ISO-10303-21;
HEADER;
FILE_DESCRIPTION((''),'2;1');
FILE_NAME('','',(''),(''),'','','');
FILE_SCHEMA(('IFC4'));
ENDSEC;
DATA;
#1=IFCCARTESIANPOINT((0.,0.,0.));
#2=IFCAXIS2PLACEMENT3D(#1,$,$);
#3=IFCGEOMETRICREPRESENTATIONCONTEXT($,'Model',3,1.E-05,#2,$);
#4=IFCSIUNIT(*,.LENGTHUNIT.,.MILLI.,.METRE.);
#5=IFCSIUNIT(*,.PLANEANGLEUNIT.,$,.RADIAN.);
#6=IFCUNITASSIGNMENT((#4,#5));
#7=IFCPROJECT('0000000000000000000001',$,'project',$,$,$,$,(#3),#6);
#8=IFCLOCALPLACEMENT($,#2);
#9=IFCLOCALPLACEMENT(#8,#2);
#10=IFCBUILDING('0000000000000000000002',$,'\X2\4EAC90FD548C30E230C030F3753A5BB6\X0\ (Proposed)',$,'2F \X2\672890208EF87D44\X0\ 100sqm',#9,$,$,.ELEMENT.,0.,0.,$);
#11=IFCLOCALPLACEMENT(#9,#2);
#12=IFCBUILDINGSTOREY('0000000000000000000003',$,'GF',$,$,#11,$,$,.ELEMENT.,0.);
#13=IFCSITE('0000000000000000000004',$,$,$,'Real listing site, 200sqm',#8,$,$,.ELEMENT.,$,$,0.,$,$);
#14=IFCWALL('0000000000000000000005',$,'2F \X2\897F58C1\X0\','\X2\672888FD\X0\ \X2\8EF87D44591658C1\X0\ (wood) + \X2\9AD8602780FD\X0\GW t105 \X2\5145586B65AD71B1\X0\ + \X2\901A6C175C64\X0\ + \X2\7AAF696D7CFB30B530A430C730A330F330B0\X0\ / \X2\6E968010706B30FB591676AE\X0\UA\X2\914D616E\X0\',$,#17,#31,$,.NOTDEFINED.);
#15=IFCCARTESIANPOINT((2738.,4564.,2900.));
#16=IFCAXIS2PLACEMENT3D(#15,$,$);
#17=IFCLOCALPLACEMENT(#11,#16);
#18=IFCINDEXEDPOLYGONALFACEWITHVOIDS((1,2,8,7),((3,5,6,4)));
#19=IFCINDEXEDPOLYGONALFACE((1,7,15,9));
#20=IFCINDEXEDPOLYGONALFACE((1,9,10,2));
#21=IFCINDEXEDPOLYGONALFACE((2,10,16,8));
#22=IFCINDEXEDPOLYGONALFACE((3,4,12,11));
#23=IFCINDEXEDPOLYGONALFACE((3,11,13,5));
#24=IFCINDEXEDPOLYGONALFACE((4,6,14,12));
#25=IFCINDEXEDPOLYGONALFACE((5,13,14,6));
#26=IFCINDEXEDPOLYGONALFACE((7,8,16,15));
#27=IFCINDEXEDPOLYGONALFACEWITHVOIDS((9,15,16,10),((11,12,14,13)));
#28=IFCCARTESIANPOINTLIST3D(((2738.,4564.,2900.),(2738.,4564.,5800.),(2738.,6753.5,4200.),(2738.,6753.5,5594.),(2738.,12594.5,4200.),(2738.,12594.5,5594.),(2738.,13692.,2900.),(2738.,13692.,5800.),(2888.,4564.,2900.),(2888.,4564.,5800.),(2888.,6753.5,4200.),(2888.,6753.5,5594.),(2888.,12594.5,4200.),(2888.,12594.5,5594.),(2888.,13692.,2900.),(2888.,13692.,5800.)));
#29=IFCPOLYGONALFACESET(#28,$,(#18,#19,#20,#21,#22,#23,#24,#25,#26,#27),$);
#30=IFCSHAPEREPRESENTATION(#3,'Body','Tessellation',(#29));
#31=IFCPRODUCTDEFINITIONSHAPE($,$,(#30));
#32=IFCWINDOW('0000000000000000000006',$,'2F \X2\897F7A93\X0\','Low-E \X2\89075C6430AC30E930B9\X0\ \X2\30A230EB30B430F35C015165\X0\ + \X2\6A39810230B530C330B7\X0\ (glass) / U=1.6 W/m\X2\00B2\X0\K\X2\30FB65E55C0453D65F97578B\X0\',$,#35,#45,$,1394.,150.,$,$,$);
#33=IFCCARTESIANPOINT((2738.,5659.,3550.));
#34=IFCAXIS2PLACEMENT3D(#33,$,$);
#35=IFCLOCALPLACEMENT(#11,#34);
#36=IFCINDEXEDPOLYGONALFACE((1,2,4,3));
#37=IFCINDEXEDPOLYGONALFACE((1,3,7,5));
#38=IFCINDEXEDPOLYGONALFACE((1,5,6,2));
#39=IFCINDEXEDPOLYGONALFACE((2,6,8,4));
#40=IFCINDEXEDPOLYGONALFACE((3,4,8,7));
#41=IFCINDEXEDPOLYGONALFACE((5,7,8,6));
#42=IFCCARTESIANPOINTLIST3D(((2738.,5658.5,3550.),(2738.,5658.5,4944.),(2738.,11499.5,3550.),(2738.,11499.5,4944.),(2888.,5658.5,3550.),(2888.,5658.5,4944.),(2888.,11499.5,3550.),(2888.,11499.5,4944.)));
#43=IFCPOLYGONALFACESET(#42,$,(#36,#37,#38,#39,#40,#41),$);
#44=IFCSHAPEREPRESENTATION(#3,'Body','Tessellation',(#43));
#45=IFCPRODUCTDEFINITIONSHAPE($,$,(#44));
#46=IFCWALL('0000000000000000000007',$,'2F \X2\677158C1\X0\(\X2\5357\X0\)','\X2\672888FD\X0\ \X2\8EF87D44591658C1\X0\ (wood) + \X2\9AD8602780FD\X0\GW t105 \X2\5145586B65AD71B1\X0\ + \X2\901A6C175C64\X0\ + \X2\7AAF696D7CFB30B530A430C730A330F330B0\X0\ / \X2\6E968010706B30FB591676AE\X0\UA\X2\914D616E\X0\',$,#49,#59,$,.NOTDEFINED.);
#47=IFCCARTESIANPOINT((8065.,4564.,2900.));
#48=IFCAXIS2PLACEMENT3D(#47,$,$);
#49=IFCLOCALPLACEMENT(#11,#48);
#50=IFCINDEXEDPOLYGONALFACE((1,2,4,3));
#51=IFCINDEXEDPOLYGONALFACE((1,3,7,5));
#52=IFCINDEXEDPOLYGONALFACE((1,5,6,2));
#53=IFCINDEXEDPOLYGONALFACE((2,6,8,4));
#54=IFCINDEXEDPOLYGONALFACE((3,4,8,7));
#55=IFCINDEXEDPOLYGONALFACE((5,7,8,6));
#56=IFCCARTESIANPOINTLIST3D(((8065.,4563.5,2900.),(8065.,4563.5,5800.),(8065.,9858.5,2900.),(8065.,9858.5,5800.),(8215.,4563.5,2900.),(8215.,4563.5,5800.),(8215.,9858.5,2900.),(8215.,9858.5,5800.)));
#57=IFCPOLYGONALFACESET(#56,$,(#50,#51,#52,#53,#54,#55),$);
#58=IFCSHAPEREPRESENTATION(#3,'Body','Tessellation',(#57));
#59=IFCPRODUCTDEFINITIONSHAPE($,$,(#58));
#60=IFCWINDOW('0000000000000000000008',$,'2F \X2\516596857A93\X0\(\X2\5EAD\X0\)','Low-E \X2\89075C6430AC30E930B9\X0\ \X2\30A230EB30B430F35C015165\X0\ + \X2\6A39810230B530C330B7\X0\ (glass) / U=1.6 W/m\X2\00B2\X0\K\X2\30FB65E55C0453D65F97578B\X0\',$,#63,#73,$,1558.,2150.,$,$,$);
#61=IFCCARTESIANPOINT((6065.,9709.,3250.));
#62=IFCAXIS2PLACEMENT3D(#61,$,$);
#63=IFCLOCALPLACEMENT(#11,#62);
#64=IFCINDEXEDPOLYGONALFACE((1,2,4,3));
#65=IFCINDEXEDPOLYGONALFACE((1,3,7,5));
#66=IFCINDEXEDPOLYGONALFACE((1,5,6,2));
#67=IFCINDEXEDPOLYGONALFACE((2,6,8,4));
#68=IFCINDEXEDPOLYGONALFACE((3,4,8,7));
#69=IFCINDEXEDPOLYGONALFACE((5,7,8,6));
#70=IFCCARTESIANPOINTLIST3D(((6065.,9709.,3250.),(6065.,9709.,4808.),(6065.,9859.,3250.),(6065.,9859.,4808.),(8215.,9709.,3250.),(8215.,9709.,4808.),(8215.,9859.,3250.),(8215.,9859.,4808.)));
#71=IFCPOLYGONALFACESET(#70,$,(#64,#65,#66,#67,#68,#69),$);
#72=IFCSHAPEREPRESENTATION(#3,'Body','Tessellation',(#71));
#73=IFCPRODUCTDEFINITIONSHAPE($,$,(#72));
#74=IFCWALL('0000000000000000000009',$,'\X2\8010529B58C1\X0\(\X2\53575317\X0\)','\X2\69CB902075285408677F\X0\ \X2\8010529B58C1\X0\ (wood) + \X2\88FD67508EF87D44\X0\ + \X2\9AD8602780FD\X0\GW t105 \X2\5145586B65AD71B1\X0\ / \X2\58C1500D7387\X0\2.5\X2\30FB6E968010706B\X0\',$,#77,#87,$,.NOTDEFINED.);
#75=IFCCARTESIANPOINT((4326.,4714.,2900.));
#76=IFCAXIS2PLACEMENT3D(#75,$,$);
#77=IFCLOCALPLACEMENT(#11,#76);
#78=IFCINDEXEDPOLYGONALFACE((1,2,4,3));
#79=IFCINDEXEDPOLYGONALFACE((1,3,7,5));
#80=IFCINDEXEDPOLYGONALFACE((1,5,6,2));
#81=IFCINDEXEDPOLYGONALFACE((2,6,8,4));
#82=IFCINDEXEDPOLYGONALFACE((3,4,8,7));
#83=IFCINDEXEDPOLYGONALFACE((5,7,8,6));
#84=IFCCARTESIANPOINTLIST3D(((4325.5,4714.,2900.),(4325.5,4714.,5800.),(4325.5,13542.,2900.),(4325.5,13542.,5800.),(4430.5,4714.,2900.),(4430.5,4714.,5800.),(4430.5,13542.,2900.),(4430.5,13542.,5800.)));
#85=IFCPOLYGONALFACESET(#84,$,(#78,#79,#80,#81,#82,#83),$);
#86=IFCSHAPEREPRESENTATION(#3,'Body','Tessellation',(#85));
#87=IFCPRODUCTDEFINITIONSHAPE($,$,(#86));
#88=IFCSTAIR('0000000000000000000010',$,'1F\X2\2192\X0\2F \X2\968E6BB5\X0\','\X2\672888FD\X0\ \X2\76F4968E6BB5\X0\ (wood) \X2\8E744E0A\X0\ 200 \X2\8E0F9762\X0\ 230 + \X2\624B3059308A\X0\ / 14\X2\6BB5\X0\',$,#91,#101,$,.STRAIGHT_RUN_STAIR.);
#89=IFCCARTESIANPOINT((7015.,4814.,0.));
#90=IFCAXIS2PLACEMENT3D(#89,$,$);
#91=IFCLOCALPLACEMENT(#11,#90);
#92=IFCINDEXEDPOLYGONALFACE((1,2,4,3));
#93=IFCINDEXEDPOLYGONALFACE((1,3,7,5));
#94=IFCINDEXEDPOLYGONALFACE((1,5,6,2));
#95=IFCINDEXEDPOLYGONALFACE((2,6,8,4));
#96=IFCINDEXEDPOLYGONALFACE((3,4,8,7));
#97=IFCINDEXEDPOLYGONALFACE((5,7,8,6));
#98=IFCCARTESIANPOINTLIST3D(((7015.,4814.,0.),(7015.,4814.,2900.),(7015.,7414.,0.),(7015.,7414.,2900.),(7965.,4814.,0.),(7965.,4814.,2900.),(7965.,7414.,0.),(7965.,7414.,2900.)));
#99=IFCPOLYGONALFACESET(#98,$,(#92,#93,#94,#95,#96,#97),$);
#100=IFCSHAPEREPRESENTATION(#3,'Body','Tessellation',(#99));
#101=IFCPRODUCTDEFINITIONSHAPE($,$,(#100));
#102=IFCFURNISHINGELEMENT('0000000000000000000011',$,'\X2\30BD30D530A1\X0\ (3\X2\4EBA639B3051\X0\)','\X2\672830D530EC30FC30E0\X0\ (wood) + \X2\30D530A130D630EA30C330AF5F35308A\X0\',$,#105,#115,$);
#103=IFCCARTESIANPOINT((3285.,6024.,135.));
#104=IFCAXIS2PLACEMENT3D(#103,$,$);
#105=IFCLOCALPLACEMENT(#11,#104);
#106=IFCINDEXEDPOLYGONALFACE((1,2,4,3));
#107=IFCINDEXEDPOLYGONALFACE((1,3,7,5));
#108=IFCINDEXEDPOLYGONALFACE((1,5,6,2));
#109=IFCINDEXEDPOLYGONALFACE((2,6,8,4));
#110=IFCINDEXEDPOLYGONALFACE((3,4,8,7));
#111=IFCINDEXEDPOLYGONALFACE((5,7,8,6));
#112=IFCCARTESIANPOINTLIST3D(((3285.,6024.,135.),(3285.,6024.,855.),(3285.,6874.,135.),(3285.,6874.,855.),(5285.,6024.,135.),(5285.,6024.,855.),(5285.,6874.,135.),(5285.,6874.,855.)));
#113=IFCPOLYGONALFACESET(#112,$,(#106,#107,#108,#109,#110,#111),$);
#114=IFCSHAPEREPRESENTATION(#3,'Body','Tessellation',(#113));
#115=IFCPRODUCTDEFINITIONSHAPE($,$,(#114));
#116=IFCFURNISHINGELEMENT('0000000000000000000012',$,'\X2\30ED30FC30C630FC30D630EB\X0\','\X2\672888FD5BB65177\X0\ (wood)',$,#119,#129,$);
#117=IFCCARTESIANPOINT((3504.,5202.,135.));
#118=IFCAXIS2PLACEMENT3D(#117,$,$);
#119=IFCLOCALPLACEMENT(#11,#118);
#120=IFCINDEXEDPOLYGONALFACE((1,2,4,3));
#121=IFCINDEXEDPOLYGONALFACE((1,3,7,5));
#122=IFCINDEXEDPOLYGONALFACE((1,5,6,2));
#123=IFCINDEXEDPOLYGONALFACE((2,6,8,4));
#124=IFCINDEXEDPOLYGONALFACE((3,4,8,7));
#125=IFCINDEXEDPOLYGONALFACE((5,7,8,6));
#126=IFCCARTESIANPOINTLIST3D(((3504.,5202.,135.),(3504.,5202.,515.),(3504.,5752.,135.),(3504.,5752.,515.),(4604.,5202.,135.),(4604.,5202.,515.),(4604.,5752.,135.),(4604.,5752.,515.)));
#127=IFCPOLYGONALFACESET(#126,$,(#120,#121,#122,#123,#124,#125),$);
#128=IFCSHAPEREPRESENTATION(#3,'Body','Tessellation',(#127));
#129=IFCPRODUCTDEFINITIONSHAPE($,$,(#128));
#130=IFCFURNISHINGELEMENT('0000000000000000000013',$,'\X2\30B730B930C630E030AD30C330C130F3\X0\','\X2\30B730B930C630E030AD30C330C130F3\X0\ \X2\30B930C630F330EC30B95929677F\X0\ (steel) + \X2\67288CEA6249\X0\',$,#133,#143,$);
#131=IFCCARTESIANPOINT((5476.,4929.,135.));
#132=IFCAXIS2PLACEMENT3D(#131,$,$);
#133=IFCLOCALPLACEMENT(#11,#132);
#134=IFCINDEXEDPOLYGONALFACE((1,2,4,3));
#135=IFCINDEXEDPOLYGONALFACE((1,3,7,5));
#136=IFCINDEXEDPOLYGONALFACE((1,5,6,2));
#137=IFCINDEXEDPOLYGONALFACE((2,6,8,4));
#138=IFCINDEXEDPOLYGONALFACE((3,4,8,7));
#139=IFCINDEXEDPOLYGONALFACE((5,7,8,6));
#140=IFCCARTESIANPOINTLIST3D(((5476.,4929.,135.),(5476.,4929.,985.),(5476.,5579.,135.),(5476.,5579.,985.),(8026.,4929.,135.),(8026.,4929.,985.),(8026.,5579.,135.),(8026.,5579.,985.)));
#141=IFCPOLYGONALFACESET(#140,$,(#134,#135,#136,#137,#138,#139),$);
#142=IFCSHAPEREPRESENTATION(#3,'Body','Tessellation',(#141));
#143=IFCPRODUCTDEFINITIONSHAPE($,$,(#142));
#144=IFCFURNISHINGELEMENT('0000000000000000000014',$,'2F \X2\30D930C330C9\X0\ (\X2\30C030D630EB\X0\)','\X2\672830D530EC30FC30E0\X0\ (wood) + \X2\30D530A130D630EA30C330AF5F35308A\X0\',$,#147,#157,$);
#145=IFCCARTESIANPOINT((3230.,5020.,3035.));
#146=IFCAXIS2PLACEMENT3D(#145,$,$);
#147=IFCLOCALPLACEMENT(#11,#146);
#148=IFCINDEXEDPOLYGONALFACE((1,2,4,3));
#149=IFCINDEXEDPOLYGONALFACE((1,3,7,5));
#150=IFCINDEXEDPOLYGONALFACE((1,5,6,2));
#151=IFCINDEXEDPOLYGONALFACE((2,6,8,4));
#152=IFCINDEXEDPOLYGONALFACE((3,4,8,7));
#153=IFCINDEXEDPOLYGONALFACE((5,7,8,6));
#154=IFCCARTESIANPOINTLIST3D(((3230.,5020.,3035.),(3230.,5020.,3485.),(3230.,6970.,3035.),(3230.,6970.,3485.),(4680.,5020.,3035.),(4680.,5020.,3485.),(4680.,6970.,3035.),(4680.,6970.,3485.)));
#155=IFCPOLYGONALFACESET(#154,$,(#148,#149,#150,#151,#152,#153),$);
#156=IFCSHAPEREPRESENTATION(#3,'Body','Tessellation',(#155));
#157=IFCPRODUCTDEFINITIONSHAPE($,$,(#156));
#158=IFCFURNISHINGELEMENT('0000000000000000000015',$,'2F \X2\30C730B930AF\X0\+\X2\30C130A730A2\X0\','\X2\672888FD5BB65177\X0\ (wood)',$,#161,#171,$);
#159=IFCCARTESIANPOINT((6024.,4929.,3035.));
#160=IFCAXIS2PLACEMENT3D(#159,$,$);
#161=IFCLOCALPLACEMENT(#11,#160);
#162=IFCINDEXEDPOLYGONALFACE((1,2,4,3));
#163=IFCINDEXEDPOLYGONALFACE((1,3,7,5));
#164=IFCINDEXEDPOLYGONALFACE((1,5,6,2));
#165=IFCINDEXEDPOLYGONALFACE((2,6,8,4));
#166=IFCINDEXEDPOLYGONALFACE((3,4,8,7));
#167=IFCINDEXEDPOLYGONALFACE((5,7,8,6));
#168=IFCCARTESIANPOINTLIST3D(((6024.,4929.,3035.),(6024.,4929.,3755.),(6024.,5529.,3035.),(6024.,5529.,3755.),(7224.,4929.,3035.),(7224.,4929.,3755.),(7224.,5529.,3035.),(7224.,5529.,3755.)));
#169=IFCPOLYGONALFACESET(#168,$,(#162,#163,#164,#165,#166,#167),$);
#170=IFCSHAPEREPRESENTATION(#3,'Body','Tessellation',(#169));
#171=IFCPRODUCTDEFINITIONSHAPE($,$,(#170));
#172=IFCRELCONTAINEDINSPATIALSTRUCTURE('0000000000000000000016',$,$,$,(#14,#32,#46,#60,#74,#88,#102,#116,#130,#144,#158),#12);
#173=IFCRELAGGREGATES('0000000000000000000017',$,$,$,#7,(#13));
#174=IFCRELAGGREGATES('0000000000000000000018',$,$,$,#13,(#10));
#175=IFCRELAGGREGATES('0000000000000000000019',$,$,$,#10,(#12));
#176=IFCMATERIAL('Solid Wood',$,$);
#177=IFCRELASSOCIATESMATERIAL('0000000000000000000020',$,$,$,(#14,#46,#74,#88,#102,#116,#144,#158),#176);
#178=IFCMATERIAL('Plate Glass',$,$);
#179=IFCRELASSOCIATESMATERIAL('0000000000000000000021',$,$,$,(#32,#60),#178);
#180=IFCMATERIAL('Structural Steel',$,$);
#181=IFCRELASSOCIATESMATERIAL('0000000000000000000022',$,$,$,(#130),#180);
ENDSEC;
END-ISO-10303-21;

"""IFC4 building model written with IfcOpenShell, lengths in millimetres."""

from ifc_helpers import new_model, si_unit, frame, frame_2d, origin, place, context, project, spatial, rectangle, extrude, material, element, fill, save


model = new_model("IFC4")

# Units and contexts
model_context = context("Model", 3, precision=1e-05, world=origin())
ifc_project = project(units=[si_unit("LENGTHUNIT", "METRE", prefix="MILLI"), si_unit("PLANEANGLEUNIT", "RADIAN")], contexts=[model_context])

# Site, building, storey
site_placement = place(None, origin())
site = spatial("IfcSite", under=ifc_project, at=site_placement, ObjectType="Real listing site, 200sqm", CompositionType="ELEMENT", RefElevation=0.0)
building_placement = place(site_placement, origin())
building = spatial("IfcBuilding", under=site, at=building_placement, Name="京都和モダン町家 (Proposed)", ObjectType="2F 木造軸組 100sqm", CompositionType="ELEMENT", ElevationOfRefHeight=0.0, ElevationOfTerrain=0.0)
storey_placement = place(building_placement, origin())
storey = spatial("IfcBuildingStorey", under=building, at=storey_placement, Name="GF", CompositionType="ELEMENT", Elevation=0.0)

# Shared definitions
ifc_material_1 = material(Name="Solid Wood")

# Shared definitions
ifc_material_2 = material(Name="Plate Glass")

# Walls, openings, windows
wall_1_placement = place(storey_placement, frame((2738.0, 4564.0, 2900.0)))
wall_1 = element("IfcWall", 1, at=wall_1_placement, inside=storey, material=ifc_material_1, Name="2F 西壁", Description="木製 軸組外壁 (wood) + 高性能GW t105 充填断熱 + 通気層 + 窯業系サイディング / 準耐火・外皮UA配慮", PredefinedType="NOTDEFINED", context=model_context, shape_type="SweptSolid", body=[
    extrude(rectangle(XDim=150.0, YDim=9128.0, at=frame_2d((75.0, 4564.0))), frame((2738.0, 4564.0, 2900.0)), (0.0, 0.0, 1.0), 2900.0),
])
opening_1_placement = place(storey_placement, frame((2738.0, 5659.0, 3550.0)))
opening_1 = element("IfcOpeningElement", 2, at=opening_1_placement, cuts=wall_1, PredefinedType="NOTDEFINED", context=model_context, shape_type="SweptSolid", body=[
    extrude(rectangle(XDim=150.0, YDim=5841.0, at=frame_2d((75.0, 2920.0))), frame((2738.0, 5659.0, 3550.0)), (0.0, 0.0, 1.0), 1394.0),
])
window_1_placement = place(storey_placement, frame((2738.0, 5659.0, 3550.0)))
window_1 = element("IfcWindow", 3, at=window_1_placement, inside=storey, material=ifc_material_2, Name="2F 西窓", Description="Low-E 複層ガラス アルゴン封入 + 樹脂サッシ (glass) / U=1.6 W/m²K・日射取得型", OverallHeight=1394.0, OverallWidth=150.0, context=model_context, shape_type="SweptSolid", body=[
    extrude(rectangle(XDim=150.0, YDim=5841.0, at=frame_2d((75.0, 2920.0))), frame((2738.0, 5659.0, 3550.0)), (0.0, 0.0, 1.0), 1394.0),
])
fill(opening_1, window_1)
wall_2_placement = place(storey_placement, frame((8065.0, 4564.0, 2900.0)))
wall_2 = element("IfcWall", 4, at=wall_2_placement, inside=storey, material=ifc_material_1, Name="2F 東壁(南)", Description="木製 軸組外壁 (wood) + 高性能GW t105 充填断熱 + 通気層 + 窯業系サイディング / 準耐火・外皮UA配慮", PredefinedType="NOTDEFINED", context=model_context, shape_type="SweptSolid", body=[
    extrude(rectangle(XDim=150.0, YDim=5295.0, at=frame_2d((75.0, 2647.0))), frame((8065.0, 4564.0, 2900.0)), (0.0, 0.0, 1.0), 2900.0),
])
opening_2_placement = place(storey_placement, frame((6065.0, 9709.0, 3250.0)))
opening_2 = element("IfcOpeningElement", 5, at=opening_2_placement, cuts=wall_2, PredefinedType="NOTDEFINED", context=model_context, shape_type="SweptSolid", body=[
    extrude(rectangle(XDim=2150.0, YDim=150.0, at=frame_2d((1075.0, 75.0))), frame((6065.0, 9709.0, 3250.0)), (0.0, 0.0, 1.0), 1558.0),
])
window_2_placement = place(storey_placement, frame((6065.0, 9709.0, 3250.0)))
window_2 = element("IfcWindow", 6, at=window_2_placement, inside=storey, material=ifc_material_2, Name="2F 入隅窓(庭)", Description="Low-E 複層ガラス アルゴン封入 + 樹脂サッシ (glass) / U=1.6 W/m²K・日射取得型", OverallHeight=1558.0, OverallWidth=2150.0, context=model_context, shape_type="SweptSolid", body=[
    extrude(rectangle(XDim=2150.0, YDim=150.0, at=frame_2d((1075.0, 75.0))), frame((6065.0, 9709.0, 3250.0)), (0.0, 0.0, 1.0), 1558.0),
])
fill(opening_2, window_2)

# Wall
wall_3_placement = place(storey_placement, frame((4326.0, 4714.0, 2900.0)))
element("IfcWall", 7, at=wall_3_placement, inside=storey, material=ifc_material_1, Name="耐力壁(南北)", Description="構造用合板 耐力壁 (wood) + 製材軸組 + 高性能GW t105 充填断熱 / 壁倍率2.5・準耐火", PredefinedType="NOTDEFINED", context=model_context, shape_type="SweptSolid", body=[
    extrude(rectangle(XDim=105.0, YDim=8828.0, at=frame_2d((52.0, 4414.0))), frame((4326.0, 4714.0, 2900.0)), (0.0, 0.0, 1.0), 2900.0),
])

# Stair
stair_placement = place(storey_placement, frame((7015.0, 4814.0, 0.0)))
element("IfcStair", 8, at=stair_placement, inside=storey, material=ifc_material_1, Name="1F→2F 階段", Description="木製 直階段 (wood) 蹴上 200 踏面 230 + 手すり / 14段", PredefinedType="STRAIGHT_RUN_STAIR", context=model_context, shape_type="SweptSolid", body=[
    extrude(rectangle(XDim=950.0, YDim=2600.0, at=frame_2d((475.0, 1300.0))), frame((7015.0, 4814.0, 0.0)), (0.0, 0.0, 1.0), 2900.0),
])

# Shared definitions
ifc_material_3 = material(Name="Structural Steel")

# Furnishing elements
furnishing_1_placement = place(storey_placement, frame((3285.0, 6024.0, 135.0)))
element("IfcFurnishingElement", 9, at=furnishing_1_placement, inside=storey, material=ifc_material_1, Name="ソファ (3人掛け)", Description="木フレーム (wood) + ファブリック張り", context=model_context, shape_type="SweptSolid", body=[
    extrude(rectangle(XDim=2000.0, YDim=850.0, at=frame_2d((1000.0, 425.0))), frame((3285.0, 6024.0, 135.0)), (0.0, 0.0, 1.0), 720.0),
])
furnishing_2_placement = place(storey_placement, frame((3504.0, 5202.0, 135.0)))
element("IfcFurnishingElement", 10, at=furnishing_2_placement, inside=storey, material=ifc_material_1, Name="ローテーブル", Description="木製家具 (wood)", context=model_context, shape_type="SweptSolid", body=[
    extrude(rectangle(XDim=1100.0, YDim=550.0, at=frame_2d((550.0, 275.0))), frame((3504.0, 5202.0, 135.0)), (0.0, 0.0, 1.0), 380.0),
])
furnishing_3_placement = place(storey_placement, frame((5476.0, 4929.0, 135.0)))
element("IfcFurnishingElement", 11, at=furnishing_3_placement, inside=storey, material=ifc_material_3, Name="システムキッチン", Description="システムキッチン ステンレス天板 (steel) + 木質扉", context=model_context, shape_type="SweptSolid", body=[
    extrude(rectangle(XDim=2550.0, YDim=650.0, at=frame_2d((1275.0, 325.0))), frame((5476.0, 4929.0, 135.0)), (0.0, 0.0, 1.0), 850.0),
])
furnishing_4_placement = place(storey_placement, frame((3230.0, 5020.0, 3035.0)))
element("IfcFurnishingElement", 12, at=furnishing_4_placement, inside=storey, material=ifc_material_1, Name="2F ベッド (ダブル)", Description="木フレーム (wood) + ファブリック張り", context=model_context, shape_type="SweptSolid", body=[
    extrude(rectangle(XDim=1450.0, YDim=1950.0, at=frame_2d((725.0, 975.0))), frame((3230.0, 5020.0, 3035.0)), (0.0, 0.0, 1.0), 450.0),
])
furnishing_5_placement = place(storey_placement, frame((6024.0, 4929.0, 3035.0)))
element("IfcFurnishingElement", 13, at=furnishing_5_placement, inside=storey, material=ifc_material_1, Name="2F デスク+チェア", Description="木製家具 (wood)", context=model_context, shape_type="SweptSolid", body=[
    extrude(rectangle(XDim=1200.0, YDim=600.0, at=frame_2d((600.0, 300.0))), frame((6024.0, 4929.0, 3035.0)), (0.0, 0.0, 1.0), 720.0),
])

save(model, "model.ifc")
